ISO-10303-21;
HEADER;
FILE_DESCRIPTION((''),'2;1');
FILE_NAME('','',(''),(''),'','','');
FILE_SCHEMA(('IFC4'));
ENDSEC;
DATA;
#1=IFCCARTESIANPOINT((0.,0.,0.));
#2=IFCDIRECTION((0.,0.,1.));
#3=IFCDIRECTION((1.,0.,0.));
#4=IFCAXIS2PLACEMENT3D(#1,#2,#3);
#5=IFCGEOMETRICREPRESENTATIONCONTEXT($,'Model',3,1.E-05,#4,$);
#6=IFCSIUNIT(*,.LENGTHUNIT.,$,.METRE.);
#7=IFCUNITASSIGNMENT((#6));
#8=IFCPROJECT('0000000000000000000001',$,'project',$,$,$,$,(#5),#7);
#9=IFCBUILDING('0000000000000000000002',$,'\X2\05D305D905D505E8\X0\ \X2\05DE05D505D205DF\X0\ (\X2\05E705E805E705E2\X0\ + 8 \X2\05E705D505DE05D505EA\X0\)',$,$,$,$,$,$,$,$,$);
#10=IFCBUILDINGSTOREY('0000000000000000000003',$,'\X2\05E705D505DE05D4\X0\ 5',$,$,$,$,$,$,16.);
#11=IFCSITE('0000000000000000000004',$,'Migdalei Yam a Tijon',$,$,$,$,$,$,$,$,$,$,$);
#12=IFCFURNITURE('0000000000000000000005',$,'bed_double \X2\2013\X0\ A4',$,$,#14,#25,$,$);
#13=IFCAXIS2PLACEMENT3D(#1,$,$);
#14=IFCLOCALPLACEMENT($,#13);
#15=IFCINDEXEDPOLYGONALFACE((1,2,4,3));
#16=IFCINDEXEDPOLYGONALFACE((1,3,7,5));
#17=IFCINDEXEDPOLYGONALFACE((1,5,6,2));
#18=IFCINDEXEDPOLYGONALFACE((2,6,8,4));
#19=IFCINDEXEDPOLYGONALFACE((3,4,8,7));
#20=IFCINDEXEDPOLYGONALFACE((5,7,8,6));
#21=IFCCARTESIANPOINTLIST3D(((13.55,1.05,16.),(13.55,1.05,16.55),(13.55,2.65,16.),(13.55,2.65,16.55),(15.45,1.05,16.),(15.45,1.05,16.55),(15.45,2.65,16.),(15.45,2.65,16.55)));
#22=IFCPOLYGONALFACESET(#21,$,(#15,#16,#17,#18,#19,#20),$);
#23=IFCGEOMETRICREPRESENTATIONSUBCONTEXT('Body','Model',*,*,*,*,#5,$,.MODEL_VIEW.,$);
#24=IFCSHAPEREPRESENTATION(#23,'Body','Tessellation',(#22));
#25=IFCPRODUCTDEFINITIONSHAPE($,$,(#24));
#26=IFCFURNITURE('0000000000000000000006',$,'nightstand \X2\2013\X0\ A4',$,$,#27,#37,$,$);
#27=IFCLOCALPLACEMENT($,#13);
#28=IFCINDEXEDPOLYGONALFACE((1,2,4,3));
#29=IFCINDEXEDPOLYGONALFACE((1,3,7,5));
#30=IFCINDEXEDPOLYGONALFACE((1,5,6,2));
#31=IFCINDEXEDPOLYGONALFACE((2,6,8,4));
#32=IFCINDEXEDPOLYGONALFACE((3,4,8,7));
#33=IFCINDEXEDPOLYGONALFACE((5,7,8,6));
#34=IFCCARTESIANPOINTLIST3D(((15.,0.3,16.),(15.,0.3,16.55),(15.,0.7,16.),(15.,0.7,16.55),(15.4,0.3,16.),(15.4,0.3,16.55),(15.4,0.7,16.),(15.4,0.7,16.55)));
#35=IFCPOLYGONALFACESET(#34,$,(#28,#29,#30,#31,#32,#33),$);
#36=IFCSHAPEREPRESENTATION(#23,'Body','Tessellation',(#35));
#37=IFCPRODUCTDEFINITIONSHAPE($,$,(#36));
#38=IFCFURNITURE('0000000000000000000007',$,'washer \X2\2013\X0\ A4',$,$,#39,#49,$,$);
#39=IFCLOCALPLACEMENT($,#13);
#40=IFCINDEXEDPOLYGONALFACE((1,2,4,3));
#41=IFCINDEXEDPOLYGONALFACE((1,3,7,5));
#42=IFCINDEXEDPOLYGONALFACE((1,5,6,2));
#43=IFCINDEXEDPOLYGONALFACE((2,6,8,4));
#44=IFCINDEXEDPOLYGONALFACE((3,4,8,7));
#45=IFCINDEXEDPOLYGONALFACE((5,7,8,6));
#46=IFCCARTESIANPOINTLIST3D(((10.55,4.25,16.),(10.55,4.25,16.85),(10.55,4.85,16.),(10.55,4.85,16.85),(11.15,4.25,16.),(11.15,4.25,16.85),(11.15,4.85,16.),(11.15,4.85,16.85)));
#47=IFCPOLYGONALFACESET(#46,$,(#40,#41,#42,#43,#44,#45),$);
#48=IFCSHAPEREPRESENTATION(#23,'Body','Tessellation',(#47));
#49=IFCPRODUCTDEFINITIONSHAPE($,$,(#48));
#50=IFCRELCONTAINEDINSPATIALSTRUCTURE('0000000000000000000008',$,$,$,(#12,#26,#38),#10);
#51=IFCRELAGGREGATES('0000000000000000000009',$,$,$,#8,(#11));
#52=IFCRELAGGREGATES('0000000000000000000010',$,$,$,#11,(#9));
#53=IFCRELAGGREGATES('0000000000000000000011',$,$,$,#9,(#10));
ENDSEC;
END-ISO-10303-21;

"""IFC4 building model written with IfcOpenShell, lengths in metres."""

from ifc_helpers import new_model, si_unit, frame, origin_with_axes, context, subcontext, project, spatial, line, indexed_curve, outline, extrude, element, save


model = new_model("IFC4")

# Units and contexts
model_context = context("Model", 3, precision=1e-05, world=origin_with_axes())
body_context = subcontext(model_context, "Body", "Model", "MODEL_VIEW")
ifc_project = project(units=[si_unit("LENGTHUNIT", "METRE")], contexts=[model_context])

# Site, building, storey
site = spatial("IfcSite", under=ifc_project, Name="Migdalei Yam a Tijon")
building = spatial("IfcBuilding", under=site, Name="דיור מוגן (קרקע + 8 קומות)")
storey = spatial("IfcBuildingStorey", under=building, Name="קומה 5", Elevation=16.0)

# Furniture
element("IfcFurniture", 1, inside=storey, Name="bed_double – A4", context=body_context, shape_type="SweptSolid", body=[
    extrude(outline(indexed_curve([(0.0, 0.0), (1.9, 0.0), (1.9, 1.6), (0.0, 1.6)], segments=[line(1, 2, 3, 4, 1)])), frame((13.55, 1.05, 16.0), z_axis=(0.0, 0.0, 1.0), x_axis=(1.0, 0.0, 0.0)), (0.0, 0.0, 1.0), 0.55),
])
element("IfcFurniture", 2, inside=storey, Name="nightstand – A4", context=body_context, shape_type="SweptSolid", body=[
    extrude(outline(indexed_curve([(0.0, 0.0), (0.4, 0.0), (0.4, 0.4), (0.0, 0.4)], segments=[line(1, 2, 3, 4, 1)])), frame((15.0, 0.3, 16.0), z_axis=(0.0, 0.0, 1.0), x_axis=(1.0, 0.0, 0.0)), (0.0, 0.0, 1.0), 0.55),
])
element("IfcFurniture", 3, inside=storey, Name="washer – A4", context=body_context, shape_type="SweptSolid", body=[
    extrude(outline(indexed_curve([(0.0, 0.0), (0.6, 0.0), (0.6, 0.6), (0.0, 0.6)], segments=[line(1, 2, 3, 4, 1)])), frame((10.55, 4.25, 16.0), z_axis=(0.0, 0.0, 1.0), x_axis=(1.0, 0.0, 0.0)), (0.0, 0.0, 1.0), 0.85),
])

save(model, "model.ifc")
